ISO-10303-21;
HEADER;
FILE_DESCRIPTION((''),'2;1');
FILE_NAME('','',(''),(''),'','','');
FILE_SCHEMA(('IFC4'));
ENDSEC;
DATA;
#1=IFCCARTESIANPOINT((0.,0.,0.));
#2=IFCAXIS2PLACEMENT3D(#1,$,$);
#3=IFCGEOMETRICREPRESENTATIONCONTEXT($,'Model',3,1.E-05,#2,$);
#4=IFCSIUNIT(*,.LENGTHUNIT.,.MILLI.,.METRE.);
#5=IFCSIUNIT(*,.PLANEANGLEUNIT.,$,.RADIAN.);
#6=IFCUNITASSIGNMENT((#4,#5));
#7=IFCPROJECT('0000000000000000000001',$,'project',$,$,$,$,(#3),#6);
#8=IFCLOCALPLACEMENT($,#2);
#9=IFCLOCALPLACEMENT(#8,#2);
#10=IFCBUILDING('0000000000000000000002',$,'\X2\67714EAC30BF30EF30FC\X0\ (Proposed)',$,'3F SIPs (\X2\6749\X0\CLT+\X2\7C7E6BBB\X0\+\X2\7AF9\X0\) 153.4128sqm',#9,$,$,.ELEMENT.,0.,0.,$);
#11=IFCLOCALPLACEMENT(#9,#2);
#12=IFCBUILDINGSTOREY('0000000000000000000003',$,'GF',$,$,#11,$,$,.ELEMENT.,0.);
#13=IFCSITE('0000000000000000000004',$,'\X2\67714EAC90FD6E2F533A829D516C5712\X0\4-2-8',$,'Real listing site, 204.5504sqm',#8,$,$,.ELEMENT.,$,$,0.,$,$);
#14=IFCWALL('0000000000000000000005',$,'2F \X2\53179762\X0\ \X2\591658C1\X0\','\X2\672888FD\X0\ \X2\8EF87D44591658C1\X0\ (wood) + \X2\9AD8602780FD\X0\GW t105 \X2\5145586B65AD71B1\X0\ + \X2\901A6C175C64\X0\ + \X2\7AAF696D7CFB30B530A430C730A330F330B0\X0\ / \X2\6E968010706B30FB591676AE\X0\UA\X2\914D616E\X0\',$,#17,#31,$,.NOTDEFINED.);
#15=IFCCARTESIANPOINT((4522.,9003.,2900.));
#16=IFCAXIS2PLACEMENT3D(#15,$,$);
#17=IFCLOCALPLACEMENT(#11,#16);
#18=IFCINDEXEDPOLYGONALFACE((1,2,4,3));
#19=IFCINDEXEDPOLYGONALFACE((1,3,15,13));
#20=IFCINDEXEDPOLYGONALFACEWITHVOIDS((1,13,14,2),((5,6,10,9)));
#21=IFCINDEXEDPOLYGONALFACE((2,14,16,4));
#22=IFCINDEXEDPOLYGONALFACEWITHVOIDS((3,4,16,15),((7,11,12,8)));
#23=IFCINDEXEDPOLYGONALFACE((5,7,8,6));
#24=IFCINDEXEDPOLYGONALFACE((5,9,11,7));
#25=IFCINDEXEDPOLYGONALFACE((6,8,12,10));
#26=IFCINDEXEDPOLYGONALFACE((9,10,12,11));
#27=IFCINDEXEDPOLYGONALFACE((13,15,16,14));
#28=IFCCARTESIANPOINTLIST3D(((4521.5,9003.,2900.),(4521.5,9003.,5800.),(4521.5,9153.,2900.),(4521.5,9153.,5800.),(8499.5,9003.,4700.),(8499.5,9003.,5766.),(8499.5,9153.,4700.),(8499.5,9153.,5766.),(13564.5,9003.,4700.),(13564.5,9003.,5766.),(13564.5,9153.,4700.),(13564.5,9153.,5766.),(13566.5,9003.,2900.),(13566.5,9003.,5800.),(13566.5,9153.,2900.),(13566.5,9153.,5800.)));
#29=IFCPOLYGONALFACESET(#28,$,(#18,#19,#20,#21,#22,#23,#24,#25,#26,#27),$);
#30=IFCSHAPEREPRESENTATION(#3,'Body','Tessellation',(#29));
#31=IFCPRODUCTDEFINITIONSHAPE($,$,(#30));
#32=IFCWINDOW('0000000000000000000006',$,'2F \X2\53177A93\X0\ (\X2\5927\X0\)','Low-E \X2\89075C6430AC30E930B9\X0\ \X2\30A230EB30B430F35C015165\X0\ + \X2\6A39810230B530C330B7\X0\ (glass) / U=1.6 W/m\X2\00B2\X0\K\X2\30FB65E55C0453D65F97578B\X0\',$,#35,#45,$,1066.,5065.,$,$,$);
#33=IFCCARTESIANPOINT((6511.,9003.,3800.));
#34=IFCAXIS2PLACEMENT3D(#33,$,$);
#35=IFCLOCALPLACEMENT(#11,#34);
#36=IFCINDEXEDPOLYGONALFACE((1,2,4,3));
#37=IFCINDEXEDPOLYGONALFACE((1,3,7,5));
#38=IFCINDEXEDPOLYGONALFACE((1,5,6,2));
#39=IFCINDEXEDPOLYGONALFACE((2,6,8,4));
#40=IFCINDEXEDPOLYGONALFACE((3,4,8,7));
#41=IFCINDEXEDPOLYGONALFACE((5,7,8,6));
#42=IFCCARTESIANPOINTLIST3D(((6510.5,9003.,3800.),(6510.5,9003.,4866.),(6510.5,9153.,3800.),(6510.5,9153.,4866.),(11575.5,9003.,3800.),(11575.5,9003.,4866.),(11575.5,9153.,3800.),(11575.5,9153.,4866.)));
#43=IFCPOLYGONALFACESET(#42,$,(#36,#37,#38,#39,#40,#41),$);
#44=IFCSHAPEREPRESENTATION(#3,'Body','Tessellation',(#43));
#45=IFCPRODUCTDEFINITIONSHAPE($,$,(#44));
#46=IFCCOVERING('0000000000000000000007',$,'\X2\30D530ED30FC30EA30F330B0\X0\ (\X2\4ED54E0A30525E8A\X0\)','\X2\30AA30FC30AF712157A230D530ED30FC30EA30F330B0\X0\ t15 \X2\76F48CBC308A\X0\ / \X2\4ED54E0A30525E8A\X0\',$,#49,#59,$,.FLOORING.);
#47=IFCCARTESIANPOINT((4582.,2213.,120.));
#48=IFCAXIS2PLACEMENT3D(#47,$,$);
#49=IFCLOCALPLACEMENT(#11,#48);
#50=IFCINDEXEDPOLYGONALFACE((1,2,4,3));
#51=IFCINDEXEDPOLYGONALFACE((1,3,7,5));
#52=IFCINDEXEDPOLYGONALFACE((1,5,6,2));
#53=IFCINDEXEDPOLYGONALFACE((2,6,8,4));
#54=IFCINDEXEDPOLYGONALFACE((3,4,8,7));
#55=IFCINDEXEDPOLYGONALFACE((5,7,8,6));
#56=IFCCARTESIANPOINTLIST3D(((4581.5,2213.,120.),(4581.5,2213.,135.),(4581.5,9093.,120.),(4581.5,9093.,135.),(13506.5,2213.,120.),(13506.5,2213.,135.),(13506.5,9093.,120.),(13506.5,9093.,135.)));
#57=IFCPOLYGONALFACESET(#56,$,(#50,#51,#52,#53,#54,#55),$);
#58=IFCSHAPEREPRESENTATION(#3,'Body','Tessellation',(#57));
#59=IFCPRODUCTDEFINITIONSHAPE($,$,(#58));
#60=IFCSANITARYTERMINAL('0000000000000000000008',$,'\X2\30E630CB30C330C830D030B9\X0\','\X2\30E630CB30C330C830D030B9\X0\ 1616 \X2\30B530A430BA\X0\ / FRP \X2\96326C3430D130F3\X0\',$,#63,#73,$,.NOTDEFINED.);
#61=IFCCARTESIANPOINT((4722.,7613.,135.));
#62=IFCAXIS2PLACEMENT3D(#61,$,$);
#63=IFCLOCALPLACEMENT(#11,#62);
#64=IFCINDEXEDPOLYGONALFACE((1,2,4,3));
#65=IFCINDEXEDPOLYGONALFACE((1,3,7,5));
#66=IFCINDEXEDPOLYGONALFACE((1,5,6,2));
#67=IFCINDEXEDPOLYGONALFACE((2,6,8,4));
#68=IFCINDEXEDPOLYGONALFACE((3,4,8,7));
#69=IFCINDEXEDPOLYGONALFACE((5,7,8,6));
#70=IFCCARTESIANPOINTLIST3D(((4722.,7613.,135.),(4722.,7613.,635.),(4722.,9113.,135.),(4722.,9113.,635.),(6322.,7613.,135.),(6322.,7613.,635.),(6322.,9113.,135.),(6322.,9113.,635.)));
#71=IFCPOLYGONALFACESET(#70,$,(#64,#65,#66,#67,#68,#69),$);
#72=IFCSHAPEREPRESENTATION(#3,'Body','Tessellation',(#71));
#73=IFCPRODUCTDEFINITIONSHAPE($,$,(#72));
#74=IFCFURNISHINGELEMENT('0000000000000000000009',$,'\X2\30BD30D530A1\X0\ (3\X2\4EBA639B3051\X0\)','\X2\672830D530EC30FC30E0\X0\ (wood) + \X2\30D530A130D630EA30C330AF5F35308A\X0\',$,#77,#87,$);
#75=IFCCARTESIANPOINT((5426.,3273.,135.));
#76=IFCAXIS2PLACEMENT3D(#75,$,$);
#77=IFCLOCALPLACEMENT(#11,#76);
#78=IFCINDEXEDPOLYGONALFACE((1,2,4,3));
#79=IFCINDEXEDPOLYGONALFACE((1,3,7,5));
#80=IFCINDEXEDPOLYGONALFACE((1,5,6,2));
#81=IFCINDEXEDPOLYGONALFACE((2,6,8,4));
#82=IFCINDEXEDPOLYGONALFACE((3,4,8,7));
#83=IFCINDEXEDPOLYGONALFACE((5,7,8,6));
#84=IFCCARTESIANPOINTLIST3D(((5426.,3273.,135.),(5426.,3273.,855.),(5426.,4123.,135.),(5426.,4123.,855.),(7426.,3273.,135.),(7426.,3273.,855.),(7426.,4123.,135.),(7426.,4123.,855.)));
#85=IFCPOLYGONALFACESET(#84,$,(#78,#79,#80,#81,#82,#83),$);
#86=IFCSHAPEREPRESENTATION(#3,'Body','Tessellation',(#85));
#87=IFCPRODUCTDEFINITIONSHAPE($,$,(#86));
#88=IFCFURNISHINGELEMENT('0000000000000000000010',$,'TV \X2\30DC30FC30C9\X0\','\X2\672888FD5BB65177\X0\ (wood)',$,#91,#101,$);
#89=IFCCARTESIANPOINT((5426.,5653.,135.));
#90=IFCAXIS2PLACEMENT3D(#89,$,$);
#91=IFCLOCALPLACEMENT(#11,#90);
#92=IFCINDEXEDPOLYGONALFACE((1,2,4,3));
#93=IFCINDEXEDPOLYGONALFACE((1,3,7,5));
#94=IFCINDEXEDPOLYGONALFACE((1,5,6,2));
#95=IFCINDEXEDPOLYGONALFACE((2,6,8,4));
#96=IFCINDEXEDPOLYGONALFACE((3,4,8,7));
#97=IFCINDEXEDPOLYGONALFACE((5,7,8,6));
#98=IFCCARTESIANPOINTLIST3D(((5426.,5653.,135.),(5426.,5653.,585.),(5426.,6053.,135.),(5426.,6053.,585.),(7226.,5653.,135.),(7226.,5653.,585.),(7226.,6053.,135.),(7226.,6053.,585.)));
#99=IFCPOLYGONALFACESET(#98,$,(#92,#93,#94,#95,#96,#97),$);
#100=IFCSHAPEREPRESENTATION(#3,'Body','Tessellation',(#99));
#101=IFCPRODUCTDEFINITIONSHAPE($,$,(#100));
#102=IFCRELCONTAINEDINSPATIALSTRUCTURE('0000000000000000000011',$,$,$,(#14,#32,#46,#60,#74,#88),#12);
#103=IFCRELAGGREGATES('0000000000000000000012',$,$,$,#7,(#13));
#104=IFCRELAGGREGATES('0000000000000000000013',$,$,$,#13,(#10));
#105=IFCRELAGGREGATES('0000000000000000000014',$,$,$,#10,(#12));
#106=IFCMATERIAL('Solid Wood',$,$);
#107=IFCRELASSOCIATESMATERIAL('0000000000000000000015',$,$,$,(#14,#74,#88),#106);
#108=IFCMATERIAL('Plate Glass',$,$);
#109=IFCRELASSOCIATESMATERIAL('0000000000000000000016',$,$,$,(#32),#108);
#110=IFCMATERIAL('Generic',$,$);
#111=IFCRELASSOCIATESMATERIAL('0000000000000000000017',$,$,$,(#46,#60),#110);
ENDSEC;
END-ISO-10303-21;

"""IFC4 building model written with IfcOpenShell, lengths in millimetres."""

from ifc_helpers import new_model, si_unit, frame, frame_2d, origin, place, context, project, spatial, rectangle, extrude, material, element, fill, save


model = new_model("IFC4")

# Units and contexts
model_context = context("Model", 3, precision=1e-05, world=origin())
ifc_project = project(units=[si_unit("LENGTHUNIT", "METRE", prefix="MILLI"), si_unit("PLANEANGLEUNIT", "RADIAN")], contexts=[model_context])

# Site, building, storey
site_placement = place(None, origin())
site = spatial("IfcSite", under=ifc_project, at=site_placement, Name="東京都港区芝公園4-2-8", ObjectType="Real listing site, 204.5504sqm", CompositionType="ELEMENT", RefElevation=0.0)
building_placement = place(site_placement, origin())
building = spatial("IfcBuilding", under=site, at=building_placement, Name="東京タワー (Proposed)", ObjectType="3F SIPs (杉CLT+籾殻+竹) 153.4128sqm", CompositionType="ELEMENT", ElevationOfRefHeight=0.0, ElevationOfTerrain=0.0)
storey_placement = place(building_placement, origin())
storey = spatial("IfcBuildingStorey", under=building, at=storey_placement, Name="GF", CompositionType="ELEMENT", Elevation=0.0)

# Shared definitions
ifc_material_1 = material(Name="Solid Wood")

# Shared definitions
ifc_material_2 = material(Name="Plate Glass")

# Wall, opening, window
wall_1_placement = place(storey_placement, frame((4522.0, 9003.0, 2900.0)))
wall_1 = element("IfcWall", 1, at=wall_1_placement, inside=storey, material=ifc_material_1, Name="2F 北面 外壁", Description="木製 軸組外壁 (wood) + 高性能GW t105 充填断熱 + 通気層 + 窯業系サイディング / 準耐火・外皮UA配慮", PredefinedType="NOTDEFINED", context=model_context, shape_type="SweptSolid", body=[
    extrude(rectangle(XDim=9045.0, YDim=150.0, at=frame_2d((4522.0, 75.0))), frame((4522.0, 9003.0, 2900.0)), (0.0, 0.0, 1.0), 2900.0),
])
opening_1_placement = place(storey_placement, frame((6511.0, 9003.0, 3800.0)))
opening_1 = element("IfcOpeningElement", 2, at=opening_1_placement, cuts=wall_1, PredefinedType="NOTDEFINED", context=model_context, shape_type="SweptSolid", body=[
    extrude(rectangle(XDim=5065.0, YDim=150.0, at=frame_2d((2532.0, 75.0))), frame((6511.0, 9003.0, 3800.0)), (0.0, 0.0, 1.0), 1066.0),
])
window_1_placement = place(storey_placement, frame((6511.0, 9003.0, 3800.0)))
window_1 = element("IfcWindow", 3, at=window_1_placement, inside=storey, material=ifc_material_2, Name="2F 北窓 (大)", Description="Low-E 複層ガラス アルゴン封入 + 樹脂サッシ (glass) / U=1.6 W/m²K・日射取得型", OverallHeight=1066.0, OverallWidth=5065.0, context=model_context, shape_type="SweptSolid", body=[
    extrude(rectangle(XDim=5065.0, YDim=150.0, at=frame_2d((2532.0, 75.0))), frame((6511.0, 9003.0, 3800.0)), (0.0, 0.0, 1.0), 1066.0),
])
fill(opening_1, window_1)

# Covering
ifc_material_3 = material(Name="Generic")
covering_placement = place(storey_placement, frame((4582.0, 2213.0, 120.0)))
element("IfcCovering", 4, at=covering_placement, inside=storey, material=ifc_material_3, Name="フローリング (仕上げ床)", Description="オーク無垢フローリング t15 直貼り / 仕上げ床", PredefinedType="FLOORING", context=model_context, shape_type="SweptSolid", body=[
    extrude(rectangle(XDim=8925.0, YDim=6880.0, at=frame_2d((4462.0, 3440.0))), frame((4582.0, 2213.0, 120.0)), (0.0, 0.0, 1.0), 15.0),
])

# Sanitary terminal
sanitary_terminal_placement = place(storey_placement, frame((4722.0, 7613.0, 135.0)))
element("IfcSanitaryTerminal", 5, at=sanitary_terminal_placement, inside=storey, material=ifc_material_3, Name="ユニットバス", Description="ユニットバス 1616 サイズ / FRP 防水パン", PredefinedType="NOTDEFINED", context=model_context, shape_type="SweptSolid", body=[
    extrude(rectangle(XDim=1600.0, YDim=1500.0, at=frame_2d((800.0, 750.0))), frame((4722.0, 7613.0, 135.0)), (0.0, 0.0, 1.0), 500.0),
])

# Furnishing elements
furnishing_1_placement = place(storey_placement, frame((5426.0, 3273.0, 135.0)))
element("IfcFurnishingElement", 6, at=furnishing_1_placement, inside=storey, material=ifc_material_1, Name="ソファ (3人掛け)", Description="木フレーム (wood) + ファブリック張り", context=model_context, shape_type="SweptSolid", body=[
    extrude(rectangle(XDim=2000.0, YDim=850.0, at=frame_2d((1000.0, 425.0))), frame((5426.0, 3273.0, 135.0)), (0.0, 0.0, 1.0), 720.0),
])
furnishing_2_placement = place(storey_placement, frame((5426.0, 5653.0, 135.0)))
element("IfcFurnishingElement", 7, at=furnishing_2_placement, inside=storey, material=ifc_material_1, Name="TV ボード", Description="木製家具 (wood)", context=model_context, shape_type="SweptSolid", body=[
    extrude(rectangle(XDim=1800.0, YDim=400.0, at=frame_2d((900.0, 200.0))), frame((5426.0, 5653.0, 135.0)), (0.0, 0.0, 1.0), 450.0),
])

save(model, "model.ifc")
